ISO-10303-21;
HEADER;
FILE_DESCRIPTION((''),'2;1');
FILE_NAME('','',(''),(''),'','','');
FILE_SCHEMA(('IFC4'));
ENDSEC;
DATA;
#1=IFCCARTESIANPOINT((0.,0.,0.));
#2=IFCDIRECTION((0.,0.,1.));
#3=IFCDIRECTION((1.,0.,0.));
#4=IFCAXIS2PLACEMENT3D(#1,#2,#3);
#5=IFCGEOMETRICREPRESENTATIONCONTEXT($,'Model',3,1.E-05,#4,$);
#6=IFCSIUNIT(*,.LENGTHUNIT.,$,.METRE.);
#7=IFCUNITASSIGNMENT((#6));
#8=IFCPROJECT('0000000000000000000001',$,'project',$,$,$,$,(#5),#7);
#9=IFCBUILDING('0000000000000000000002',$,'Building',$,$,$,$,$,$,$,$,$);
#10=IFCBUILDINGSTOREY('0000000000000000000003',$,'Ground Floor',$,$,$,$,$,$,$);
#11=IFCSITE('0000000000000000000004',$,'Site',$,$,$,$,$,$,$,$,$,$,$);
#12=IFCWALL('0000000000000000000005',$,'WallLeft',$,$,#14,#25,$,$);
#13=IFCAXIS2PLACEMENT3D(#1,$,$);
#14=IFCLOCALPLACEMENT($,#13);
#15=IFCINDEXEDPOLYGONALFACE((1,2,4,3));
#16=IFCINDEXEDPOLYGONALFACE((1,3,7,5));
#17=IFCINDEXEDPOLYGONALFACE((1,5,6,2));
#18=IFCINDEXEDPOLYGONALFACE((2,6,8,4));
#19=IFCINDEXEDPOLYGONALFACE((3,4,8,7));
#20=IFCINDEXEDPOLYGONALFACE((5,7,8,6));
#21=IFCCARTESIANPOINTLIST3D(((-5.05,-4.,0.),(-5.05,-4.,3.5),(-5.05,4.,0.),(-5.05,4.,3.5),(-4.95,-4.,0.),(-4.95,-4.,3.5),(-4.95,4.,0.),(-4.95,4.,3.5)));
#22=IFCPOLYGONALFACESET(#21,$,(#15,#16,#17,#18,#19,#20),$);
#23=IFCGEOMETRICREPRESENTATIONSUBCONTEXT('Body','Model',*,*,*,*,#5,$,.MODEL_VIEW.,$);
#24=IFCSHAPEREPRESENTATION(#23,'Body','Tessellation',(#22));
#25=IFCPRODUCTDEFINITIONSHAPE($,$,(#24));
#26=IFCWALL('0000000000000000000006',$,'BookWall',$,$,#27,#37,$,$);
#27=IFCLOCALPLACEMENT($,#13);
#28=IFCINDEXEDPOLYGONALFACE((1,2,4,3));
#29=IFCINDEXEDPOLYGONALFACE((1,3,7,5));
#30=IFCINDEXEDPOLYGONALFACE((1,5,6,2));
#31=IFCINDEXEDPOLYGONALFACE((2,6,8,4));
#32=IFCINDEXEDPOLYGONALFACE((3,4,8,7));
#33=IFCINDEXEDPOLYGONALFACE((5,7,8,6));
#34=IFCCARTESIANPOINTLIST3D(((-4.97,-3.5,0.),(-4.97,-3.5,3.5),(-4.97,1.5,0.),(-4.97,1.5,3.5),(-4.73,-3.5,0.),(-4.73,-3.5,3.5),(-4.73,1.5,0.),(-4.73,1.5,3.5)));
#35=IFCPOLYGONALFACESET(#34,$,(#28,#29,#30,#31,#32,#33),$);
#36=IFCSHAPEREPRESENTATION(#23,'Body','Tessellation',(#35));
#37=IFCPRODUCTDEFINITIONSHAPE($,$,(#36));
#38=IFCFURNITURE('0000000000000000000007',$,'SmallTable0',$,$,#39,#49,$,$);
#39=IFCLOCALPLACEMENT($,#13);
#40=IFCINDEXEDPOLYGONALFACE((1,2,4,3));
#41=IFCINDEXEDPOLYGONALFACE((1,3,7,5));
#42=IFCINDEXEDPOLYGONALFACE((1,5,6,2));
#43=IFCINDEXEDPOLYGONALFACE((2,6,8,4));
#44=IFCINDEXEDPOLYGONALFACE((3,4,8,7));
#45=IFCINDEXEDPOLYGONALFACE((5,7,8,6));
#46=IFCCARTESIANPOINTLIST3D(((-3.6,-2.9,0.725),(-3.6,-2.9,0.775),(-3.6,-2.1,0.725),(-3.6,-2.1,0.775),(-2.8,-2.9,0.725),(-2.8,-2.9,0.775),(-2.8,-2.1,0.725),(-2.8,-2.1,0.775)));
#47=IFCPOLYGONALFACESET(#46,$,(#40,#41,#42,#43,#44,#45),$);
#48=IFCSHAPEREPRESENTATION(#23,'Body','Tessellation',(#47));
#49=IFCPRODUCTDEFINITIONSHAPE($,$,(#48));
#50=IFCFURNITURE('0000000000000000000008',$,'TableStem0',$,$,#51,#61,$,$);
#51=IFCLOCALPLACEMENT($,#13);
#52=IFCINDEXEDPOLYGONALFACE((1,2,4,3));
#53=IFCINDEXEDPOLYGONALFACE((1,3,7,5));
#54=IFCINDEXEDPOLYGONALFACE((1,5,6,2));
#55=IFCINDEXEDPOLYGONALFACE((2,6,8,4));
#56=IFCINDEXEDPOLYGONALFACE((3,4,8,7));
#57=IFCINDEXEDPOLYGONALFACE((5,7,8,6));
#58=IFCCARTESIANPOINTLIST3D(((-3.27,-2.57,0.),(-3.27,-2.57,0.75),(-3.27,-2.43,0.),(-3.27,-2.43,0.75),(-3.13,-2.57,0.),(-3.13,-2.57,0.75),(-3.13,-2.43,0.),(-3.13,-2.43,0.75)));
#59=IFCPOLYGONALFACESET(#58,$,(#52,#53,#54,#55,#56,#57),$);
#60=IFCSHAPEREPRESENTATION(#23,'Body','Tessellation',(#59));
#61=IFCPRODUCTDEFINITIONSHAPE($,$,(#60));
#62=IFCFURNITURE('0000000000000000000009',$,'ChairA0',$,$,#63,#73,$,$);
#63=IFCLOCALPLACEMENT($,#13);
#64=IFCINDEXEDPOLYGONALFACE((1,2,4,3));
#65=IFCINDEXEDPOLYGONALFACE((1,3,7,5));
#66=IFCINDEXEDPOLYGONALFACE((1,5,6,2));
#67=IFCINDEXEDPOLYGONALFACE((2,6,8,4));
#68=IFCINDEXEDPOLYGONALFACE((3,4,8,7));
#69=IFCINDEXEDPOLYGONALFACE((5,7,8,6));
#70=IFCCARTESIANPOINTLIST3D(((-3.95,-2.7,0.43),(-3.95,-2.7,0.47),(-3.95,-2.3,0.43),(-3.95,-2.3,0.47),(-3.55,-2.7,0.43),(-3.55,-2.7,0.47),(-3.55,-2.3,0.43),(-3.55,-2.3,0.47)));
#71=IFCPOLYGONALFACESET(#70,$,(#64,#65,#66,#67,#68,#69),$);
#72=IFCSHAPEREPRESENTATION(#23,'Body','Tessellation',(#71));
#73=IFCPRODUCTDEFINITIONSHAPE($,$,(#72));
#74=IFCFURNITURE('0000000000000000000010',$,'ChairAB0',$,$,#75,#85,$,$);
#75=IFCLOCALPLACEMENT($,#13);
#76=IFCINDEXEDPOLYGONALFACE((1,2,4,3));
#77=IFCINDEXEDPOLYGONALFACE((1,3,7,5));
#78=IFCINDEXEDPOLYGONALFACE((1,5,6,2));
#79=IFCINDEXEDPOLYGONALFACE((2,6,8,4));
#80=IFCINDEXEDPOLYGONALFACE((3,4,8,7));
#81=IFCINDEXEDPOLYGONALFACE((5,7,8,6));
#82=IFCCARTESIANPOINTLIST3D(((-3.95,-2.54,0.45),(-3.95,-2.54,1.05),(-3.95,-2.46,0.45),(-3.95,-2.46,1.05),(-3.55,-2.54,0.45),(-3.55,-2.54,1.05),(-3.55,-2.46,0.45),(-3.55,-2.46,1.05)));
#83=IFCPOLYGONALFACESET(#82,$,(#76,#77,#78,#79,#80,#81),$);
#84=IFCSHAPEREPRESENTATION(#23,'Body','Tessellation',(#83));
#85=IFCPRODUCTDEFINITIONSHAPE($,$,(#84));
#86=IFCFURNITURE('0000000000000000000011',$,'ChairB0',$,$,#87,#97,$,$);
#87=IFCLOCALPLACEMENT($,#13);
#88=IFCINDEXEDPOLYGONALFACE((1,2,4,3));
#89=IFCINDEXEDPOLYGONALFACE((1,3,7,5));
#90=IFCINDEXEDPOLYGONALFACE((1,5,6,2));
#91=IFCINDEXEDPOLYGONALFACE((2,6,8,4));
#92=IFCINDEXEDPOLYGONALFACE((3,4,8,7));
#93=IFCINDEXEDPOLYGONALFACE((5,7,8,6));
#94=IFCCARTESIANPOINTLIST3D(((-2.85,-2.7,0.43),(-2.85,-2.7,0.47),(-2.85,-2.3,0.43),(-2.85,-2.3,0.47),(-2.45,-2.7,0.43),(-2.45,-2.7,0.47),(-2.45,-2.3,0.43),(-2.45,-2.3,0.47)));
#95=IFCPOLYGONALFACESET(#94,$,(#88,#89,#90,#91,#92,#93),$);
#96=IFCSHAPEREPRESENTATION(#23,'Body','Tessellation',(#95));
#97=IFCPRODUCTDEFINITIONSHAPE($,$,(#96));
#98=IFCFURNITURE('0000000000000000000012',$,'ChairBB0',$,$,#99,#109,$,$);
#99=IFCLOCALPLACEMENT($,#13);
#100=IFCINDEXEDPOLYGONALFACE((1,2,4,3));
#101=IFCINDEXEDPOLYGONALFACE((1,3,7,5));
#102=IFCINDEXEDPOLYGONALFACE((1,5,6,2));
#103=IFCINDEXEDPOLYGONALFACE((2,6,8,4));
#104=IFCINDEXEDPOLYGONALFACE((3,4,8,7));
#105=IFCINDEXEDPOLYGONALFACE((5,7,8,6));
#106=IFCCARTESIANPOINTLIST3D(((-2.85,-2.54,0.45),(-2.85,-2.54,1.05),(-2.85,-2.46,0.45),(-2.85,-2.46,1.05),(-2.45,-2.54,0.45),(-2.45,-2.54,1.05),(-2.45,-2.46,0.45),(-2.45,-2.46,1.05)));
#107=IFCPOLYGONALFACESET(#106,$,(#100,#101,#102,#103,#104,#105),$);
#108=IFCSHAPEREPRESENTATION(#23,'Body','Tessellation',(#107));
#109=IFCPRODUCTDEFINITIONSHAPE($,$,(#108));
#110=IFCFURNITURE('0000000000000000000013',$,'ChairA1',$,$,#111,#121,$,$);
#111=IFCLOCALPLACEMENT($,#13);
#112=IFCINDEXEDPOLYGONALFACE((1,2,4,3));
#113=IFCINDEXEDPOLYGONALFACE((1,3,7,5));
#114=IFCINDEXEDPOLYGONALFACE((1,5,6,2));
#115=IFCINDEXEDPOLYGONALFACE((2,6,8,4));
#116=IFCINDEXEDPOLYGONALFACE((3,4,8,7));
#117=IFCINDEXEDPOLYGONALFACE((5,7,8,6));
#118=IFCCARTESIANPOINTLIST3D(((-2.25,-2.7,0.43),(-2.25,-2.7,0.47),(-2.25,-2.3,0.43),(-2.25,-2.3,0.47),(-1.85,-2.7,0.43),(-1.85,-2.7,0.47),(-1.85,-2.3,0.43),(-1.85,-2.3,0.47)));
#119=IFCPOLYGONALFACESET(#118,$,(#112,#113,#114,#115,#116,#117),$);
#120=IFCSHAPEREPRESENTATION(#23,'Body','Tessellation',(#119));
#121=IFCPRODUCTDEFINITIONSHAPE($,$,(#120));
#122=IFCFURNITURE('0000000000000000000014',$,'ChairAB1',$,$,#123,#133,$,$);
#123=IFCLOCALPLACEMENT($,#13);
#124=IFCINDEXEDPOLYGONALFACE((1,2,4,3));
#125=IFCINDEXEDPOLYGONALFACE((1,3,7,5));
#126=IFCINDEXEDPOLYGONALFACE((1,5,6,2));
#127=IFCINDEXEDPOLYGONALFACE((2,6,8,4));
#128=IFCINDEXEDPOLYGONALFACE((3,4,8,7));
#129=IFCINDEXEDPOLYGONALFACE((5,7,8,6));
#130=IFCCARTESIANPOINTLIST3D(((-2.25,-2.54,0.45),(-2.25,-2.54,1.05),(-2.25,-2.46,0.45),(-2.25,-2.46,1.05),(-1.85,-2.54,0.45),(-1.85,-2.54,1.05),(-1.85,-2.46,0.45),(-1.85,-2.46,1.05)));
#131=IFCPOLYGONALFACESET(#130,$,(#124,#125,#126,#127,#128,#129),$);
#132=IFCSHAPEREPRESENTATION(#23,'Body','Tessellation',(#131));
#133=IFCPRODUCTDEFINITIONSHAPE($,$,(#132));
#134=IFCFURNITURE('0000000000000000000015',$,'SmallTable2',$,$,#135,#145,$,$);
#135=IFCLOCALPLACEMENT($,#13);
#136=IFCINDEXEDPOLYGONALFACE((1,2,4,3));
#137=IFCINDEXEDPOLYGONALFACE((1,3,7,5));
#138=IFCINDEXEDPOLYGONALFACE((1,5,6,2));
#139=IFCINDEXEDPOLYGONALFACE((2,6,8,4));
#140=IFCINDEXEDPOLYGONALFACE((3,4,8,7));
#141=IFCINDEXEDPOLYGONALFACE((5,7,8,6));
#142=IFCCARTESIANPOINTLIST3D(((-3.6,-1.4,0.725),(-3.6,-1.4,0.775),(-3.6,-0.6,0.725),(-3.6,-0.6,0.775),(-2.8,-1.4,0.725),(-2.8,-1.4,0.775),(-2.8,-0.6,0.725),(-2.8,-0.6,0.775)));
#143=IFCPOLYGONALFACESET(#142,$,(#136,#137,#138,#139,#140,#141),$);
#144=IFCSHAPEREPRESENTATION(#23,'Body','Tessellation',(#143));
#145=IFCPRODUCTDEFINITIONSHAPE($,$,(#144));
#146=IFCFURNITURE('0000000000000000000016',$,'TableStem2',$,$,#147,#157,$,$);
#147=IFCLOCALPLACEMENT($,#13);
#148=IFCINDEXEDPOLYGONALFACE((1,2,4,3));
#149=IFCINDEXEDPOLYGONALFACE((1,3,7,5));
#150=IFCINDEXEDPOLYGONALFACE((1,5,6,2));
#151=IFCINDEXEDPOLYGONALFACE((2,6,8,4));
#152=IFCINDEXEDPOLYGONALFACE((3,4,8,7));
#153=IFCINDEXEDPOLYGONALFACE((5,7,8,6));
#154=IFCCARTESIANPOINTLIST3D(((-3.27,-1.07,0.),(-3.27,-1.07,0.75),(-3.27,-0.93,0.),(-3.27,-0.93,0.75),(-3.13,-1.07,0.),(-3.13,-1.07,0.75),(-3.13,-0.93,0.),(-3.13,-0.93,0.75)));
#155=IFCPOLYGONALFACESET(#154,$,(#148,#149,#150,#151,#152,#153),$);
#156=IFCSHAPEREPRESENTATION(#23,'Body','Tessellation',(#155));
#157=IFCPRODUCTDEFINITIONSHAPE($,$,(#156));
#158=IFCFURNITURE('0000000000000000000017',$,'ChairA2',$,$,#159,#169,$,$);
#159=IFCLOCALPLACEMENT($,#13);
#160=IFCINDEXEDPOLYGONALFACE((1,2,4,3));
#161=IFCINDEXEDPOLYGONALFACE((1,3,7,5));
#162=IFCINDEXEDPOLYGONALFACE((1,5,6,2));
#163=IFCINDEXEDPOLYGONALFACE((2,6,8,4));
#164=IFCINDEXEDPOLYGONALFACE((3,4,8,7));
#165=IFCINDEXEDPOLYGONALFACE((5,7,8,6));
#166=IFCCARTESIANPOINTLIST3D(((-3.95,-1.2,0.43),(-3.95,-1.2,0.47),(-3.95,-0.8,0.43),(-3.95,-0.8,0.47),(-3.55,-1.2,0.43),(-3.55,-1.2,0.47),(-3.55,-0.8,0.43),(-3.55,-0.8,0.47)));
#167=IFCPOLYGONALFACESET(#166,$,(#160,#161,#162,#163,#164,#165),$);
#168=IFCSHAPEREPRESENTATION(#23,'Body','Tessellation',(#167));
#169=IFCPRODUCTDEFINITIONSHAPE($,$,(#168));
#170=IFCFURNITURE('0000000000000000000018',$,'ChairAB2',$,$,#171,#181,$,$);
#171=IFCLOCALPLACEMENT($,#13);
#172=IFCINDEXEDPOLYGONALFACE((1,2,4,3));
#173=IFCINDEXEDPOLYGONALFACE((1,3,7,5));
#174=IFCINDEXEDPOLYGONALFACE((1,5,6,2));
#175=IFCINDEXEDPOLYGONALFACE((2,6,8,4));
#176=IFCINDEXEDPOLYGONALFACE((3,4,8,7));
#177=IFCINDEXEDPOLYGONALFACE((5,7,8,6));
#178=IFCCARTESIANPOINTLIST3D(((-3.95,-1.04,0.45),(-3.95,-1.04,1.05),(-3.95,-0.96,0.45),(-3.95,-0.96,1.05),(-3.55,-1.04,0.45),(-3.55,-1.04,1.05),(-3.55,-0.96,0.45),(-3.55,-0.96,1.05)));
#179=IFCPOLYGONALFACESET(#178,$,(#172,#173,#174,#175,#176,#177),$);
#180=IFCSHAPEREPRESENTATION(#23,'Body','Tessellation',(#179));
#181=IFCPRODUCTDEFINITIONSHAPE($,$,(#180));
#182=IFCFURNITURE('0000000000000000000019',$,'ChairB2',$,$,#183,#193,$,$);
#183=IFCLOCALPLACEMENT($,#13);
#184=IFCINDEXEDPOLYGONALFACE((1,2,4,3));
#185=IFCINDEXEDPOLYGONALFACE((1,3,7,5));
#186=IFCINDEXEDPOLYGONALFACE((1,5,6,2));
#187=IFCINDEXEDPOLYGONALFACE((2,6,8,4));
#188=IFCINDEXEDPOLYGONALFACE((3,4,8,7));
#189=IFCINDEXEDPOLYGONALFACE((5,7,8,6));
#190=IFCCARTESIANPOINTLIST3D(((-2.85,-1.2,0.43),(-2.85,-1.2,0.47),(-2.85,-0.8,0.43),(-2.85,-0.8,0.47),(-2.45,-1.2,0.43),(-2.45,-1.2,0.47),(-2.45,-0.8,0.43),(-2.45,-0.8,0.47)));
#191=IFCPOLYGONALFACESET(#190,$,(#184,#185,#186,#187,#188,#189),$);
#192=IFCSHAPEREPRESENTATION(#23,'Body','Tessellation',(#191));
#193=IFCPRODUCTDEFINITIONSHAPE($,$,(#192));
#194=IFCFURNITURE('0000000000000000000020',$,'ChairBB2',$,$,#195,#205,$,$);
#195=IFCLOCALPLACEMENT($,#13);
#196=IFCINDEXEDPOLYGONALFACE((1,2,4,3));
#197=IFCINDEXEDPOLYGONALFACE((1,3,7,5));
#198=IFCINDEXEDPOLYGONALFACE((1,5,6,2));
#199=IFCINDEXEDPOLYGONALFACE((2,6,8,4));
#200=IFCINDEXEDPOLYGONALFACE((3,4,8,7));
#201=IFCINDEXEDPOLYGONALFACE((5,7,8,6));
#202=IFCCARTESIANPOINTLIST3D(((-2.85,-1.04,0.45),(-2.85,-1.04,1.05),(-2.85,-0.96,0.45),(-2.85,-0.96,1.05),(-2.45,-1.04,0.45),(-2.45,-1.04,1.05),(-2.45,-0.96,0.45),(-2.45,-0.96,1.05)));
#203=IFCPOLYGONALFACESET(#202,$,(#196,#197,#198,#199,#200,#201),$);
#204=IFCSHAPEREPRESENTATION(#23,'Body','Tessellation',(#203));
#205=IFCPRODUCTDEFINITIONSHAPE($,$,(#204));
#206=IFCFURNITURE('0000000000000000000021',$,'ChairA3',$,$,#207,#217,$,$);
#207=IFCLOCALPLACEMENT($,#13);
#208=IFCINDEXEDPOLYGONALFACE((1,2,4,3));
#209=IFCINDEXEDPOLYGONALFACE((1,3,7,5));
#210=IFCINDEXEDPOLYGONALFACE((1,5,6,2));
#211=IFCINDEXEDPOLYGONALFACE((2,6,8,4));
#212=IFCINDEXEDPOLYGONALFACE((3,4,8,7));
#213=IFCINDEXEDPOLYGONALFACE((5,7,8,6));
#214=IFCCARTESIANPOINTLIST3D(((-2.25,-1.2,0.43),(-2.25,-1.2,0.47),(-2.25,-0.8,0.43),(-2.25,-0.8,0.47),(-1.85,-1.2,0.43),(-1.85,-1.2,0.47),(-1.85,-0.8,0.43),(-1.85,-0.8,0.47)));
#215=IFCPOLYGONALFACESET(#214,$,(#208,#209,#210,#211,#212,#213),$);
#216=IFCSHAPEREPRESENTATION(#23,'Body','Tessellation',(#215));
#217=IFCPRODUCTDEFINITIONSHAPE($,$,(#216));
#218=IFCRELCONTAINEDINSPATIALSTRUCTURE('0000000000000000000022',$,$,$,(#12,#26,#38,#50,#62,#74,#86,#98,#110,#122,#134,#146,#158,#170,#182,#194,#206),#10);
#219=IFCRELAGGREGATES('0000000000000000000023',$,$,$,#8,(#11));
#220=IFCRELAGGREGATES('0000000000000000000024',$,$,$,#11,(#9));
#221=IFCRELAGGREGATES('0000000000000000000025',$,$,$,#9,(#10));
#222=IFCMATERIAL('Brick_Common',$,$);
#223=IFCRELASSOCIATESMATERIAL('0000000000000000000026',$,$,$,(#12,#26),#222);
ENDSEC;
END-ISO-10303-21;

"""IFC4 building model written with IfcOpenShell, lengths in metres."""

from ifc_helpers import new_model, si_unit, frame, origin_with_axes, origin_2d, place, context, subcontext, project, spatial, rectangle, extrude, material, element, save


model = new_model("IFC4")

# Units and contexts
model_context = context("Model", 3, precision=1e-05, world=origin_with_axes())
body_context = subcontext(model_context, "Body", "Model", "MODEL_VIEW")
ifc_project = project(units=[si_unit("LENGTHUNIT", "METRE")], contexts=[model_context])

# Site, building, storey
site = spatial("IfcSite", under=ifc_project, Name="Site")
building = spatial("IfcBuilding", under=site, Name="Building")
storey = spatial("IfcBuildingStorey", under=building, Name="Ground Floor")

# Walls
ifc_material = material(Name="Brick_Common")
wall_1_placement = place(None, frame((-5.0, 0.0, 1.75), z_axis=(0.0, 0.0, 1.0), x_axis=(1.0, 0.0, 0.0)))
element("IfcWall", 1, at=wall_1_placement, inside=storey, material=ifc_material, Name="WallLeft", context=body_context, shape_type="SweptSolid", body=[
    extrude(rectangle(XDim=0.1, YDim=8.0, at=origin_2d()), frame((0.0, 0.0, -1.75)), (0.0, 0.0, 1.0), 3.5),
])
wall_2_placement = place(None, frame((-4.85, -1.0, 1.75), z_axis=(0.0, 0.0, 1.0), x_axis=(1.0, 0.0, 0.0)))
element("IfcWall", 2, at=wall_2_placement, inside=storey, material=ifc_material, Name="BookWall", context=body_context, shape_type="SweptSolid", body=[
    extrude(rectangle(XDim=0.24, YDim=5.0, at=origin_2d()), frame((0.0, 0.0, -1.75)), (0.0, 0.0, 1.0), 3.5),
])

# Furniture
furniture_1_placement = place(None, frame((-3.2, -2.5, 0.75), z_axis=(0.0, 0.0, 1.0), x_axis=(1.0, 0.0, 0.0)))
element("IfcFurniture", 3, at=furniture_1_placement, inside=storey, Name="SmallTable0", context=body_context, shape_type="SweptSolid", body=[
    extrude(rectangle(XDim=0.8, YDim=0.8, at=origin_2d()), frame((0.0, 0.0, -0.025)), (0.0, 0.0, 1.0), 0.05),
])
furniture_2_placement = place(None, frame((-3.2, -2.5, 0.375), z_axis=(0.0, 0.0, 1.0), x_axis=(1.0, 0.0, 0.0)))
element("IfcFurniture", 4, at=furniture_2_placement, inside=storey, Name="TableStem0", context=body_context, shape_type="SweptSolid", body=[
    extrude(rectangle(XDim=0.14, YDim=0.14, at=origin_2d()), frame((0.0, 0.0, -0.375)), (0.0, 0.0, 1.0), 0.75),
])
furniture_3_placement = place(None, frame((-3.75, -2.5, 0.45), z_axis=(0.0, 0.0, 1.0), x_axis=(1.0, 0.0, 0.0)))
element("IfcFurniture", 5, at=furniture_3_placement, inside=storey, Name="ChairA0", context=body_context, shape_type="SweptSolid", body=[
    extrude(rectangle(XDim=0.4, YDim=0.4, at=origin_2d()), frame((0.0, 0.0, -0.02)), (0.0, 0.0, 1.0), 0.04),
])
furniture_4_placement = place(None, frame((-3.75, -2.5, 0.75), z_axis=(0.0, 0.0, 1.0), x_axis=(1.0, 0.0, 0.0)))
element("IfcFurniture", 6, at=furniture_4_placement, inside=storey, Name="ChairAB0", context=body_context, shape_type="SweptSolid", body=[
    extrude(rectangle(XDim=0.4, YDim=0.08, at=origin_2d()), frame((0.0, 0.0, -0.3)), (0.0, 0.0, 1.0), 0.6),
])
furniture_5_placement = place(None, frame((-2.65, -2.5, 0.45), z_axis=(0.0, 0.0, 1.0), x_axis=(1.0, 0.0, 0.0)))
element("IfcFurniture", 7, at=furniture_5_placement, inside=storey, Name="ChairB0", context=body_context, shape_type="SweptSolid", body=[
    extrude(rectangle(XDim=0.4, YDim=0.4, at=origin_2d()), frame((0.0, 0.0, -0.02)), (0.0, 0.0, 1.0), 0.04),
])
furniture_6_placement = place(None, frame((-2.65, -2.5, 0.75), z_axis=(0.0, 0.0, 1.0), x_axis=(1.0, 0.0, 0.0)))
element("IfcFurniture", 8, at=furniture_6_placement, inside=storey, Name="ChairBB0", context=body_context, shape_type="SweptSolid", body=[
    extrude(rectangle(XDim=0.4, YDim=0.08, at=origin_2d()), frame((0.0, 0.0, -0.3)), (0.0, 0.0, 1.0), 0.6),
])
furniture_7_placement = place(None, frame((-2.05, -2.5, 0.45), z_axis=(0.0, 0.0, 1.0), x_axis=(1.0, 0.0, 0.0)))
element("IfcFurniture", 9, at=furniture_7_placement, inside=storey, Name="ChairA1", context=body_context, shape_type="SweptSolid", body=[
    extrude(rectangle(XDim=0.4, YDim=0.4, at=origin_2d()), frame((0.0, 0.0, -0.02)), (0.0, 0.0, 1.0), 0.04),
])
furniture_8_placement = place(None, frame((-2.05, -2.5, 0.75), z_axis=(0.0, 0.0, 1.0), x_axis=(1.0, 0.0, 0.0)))
element("IfcFurniture", 10, at=furniture_8_placement, inside=storey, Name="ChairAB1", context=body_context, shape_type="SweptSolid", body=[
    extrude(rectangle(XDim=0.4, YDim=0.08, at=origin_2d()), frame((0.0, 0.0, -0.3)), (0.0, 0.0, 1.0), 0.6),
])
furniture_9_placement = place(None, frame((-3.2, -1.0, 0.75), z_axis=(0.0, 0.0, 1.0), x_axis=(1.0, 0.0, 0.0)))
element("IfcFurniture", 11, at=furniture_9_placement, inside=storey, Name="SmallTable2", context=body_context, shape_type="SweptSolid", body=[
    extrude(rectangle(XDim=0.8, YDim=0.8, at=origin_2d()), frame((0.0, 0.0, -0.025)), (0.0, 0.0, 1.0), 0.05),
])
furniture_10_placement = place(None, frame((-3.2, -1.0, 0.375), z_axis=(0.0, 0.0, 1.0), x_axis=(1.0, 0.0, 0.0)))
element("IfcFurniture", 12, at=furniture_10_placement, inside=storey, Name="TableStem2", context=body_context, shape_type="SweptSolid", body=[
    extrude(rectangle(XDim=0.14, YDim=0.14, at=origin_2d()), frame((0.0, 0.0, -0.375)), (0.0, 0.0, 1.0), 0.75),
])
furniture_11_placement = place(None, frame((-3.75, -1.0, 0.45), z_axis=(0.0, 0.0, 1.0), x_axis=(1.0, 0.0, 0.0)))
element("IfcFurniture", 13, at=furniture_11_placement, inside=storey, Name="ChairA2", context=body_context, shape_type="SweptSolid", body=[
    extrude(rectangle(XDim=0.4, YDim=0.4, at=origin_2d()), frame((0.0, 0.0, -0.02)), (0.0, 0.0, 1.0), 0.04),
])
furniture_12_placement = place(None, frame((-3.75, -1.0, 0.75), z_axis=(0.0, 0.0, 1.0), x_axis=(1.0, 0.0, 0.0)))
element("IfcFurniture", 14, at=furniture_12_placement, inside=storey, Name="ChairAB2", context=body_context, shape_type="SweptSolid", body=[
    extrude(rectangle(XDim=0.4, YDim=0.08, at=origin_2d()), frame((0.0, 0.0, -0.3)), (0.0, 0.0, 1.0), 0.6),
])
furniture_13_placement = place(None, frame((-2.65, -1.0, 0.45), z_axis=(0.0, 0.0, 1.0), x_axis=(1.0, 0.0, 0.0)))
element("IfcFurniture", 15, at=furniture_13_placement, inside=storey, Name="ChairB2", context=body_context, shape_type="SweptSolid", body=[
    extrude(rectangle(XDim=0.4, YDim=0.4, at=origin_2d()), frame((0.0, 0.0, -0.02)), (0.0, 0.0, 1.0), 0.04),
])
furniture_14_placement = place(None, frame((-2.65, -1.0, 0.75), z_axis=(0.0, 0.0, 1.0), x_axis=(1.0, 0.0, 0.0)))
element("IfcFurniture", 16, at=furniture_14_placement, inside=storey, Name="ChairBB2", context=body_context, shape_type="SweptSolid", body=[
    extrude(rectangle(XDim=0.4, YDim=0.08, at=origin_2d()), frame((0.0, 0.0, -0.3)), (0.0, 0.0, 1.0), 0.6),
])
furniture_15_placement = place(None, frame((-2.05, -1.0, 0.45), z_axis=(0.0, 0.0, 1.0), x_axis=(1.0, 0.0, 0.0)))
element("IfcFurniture", 17, at=furniture_15_placement, inside=storey, Name="ChairA3", context=body_context, shape_type="SweptSolid", body=[
    extrude(rectangle(XDim=0.4, YDim=0.4, at=origin_2d()), frame((0.0, 0.0, -0.02)), (0.0, 0.0, 1.0), 0.04),
])

save(model, "model.ifc")
